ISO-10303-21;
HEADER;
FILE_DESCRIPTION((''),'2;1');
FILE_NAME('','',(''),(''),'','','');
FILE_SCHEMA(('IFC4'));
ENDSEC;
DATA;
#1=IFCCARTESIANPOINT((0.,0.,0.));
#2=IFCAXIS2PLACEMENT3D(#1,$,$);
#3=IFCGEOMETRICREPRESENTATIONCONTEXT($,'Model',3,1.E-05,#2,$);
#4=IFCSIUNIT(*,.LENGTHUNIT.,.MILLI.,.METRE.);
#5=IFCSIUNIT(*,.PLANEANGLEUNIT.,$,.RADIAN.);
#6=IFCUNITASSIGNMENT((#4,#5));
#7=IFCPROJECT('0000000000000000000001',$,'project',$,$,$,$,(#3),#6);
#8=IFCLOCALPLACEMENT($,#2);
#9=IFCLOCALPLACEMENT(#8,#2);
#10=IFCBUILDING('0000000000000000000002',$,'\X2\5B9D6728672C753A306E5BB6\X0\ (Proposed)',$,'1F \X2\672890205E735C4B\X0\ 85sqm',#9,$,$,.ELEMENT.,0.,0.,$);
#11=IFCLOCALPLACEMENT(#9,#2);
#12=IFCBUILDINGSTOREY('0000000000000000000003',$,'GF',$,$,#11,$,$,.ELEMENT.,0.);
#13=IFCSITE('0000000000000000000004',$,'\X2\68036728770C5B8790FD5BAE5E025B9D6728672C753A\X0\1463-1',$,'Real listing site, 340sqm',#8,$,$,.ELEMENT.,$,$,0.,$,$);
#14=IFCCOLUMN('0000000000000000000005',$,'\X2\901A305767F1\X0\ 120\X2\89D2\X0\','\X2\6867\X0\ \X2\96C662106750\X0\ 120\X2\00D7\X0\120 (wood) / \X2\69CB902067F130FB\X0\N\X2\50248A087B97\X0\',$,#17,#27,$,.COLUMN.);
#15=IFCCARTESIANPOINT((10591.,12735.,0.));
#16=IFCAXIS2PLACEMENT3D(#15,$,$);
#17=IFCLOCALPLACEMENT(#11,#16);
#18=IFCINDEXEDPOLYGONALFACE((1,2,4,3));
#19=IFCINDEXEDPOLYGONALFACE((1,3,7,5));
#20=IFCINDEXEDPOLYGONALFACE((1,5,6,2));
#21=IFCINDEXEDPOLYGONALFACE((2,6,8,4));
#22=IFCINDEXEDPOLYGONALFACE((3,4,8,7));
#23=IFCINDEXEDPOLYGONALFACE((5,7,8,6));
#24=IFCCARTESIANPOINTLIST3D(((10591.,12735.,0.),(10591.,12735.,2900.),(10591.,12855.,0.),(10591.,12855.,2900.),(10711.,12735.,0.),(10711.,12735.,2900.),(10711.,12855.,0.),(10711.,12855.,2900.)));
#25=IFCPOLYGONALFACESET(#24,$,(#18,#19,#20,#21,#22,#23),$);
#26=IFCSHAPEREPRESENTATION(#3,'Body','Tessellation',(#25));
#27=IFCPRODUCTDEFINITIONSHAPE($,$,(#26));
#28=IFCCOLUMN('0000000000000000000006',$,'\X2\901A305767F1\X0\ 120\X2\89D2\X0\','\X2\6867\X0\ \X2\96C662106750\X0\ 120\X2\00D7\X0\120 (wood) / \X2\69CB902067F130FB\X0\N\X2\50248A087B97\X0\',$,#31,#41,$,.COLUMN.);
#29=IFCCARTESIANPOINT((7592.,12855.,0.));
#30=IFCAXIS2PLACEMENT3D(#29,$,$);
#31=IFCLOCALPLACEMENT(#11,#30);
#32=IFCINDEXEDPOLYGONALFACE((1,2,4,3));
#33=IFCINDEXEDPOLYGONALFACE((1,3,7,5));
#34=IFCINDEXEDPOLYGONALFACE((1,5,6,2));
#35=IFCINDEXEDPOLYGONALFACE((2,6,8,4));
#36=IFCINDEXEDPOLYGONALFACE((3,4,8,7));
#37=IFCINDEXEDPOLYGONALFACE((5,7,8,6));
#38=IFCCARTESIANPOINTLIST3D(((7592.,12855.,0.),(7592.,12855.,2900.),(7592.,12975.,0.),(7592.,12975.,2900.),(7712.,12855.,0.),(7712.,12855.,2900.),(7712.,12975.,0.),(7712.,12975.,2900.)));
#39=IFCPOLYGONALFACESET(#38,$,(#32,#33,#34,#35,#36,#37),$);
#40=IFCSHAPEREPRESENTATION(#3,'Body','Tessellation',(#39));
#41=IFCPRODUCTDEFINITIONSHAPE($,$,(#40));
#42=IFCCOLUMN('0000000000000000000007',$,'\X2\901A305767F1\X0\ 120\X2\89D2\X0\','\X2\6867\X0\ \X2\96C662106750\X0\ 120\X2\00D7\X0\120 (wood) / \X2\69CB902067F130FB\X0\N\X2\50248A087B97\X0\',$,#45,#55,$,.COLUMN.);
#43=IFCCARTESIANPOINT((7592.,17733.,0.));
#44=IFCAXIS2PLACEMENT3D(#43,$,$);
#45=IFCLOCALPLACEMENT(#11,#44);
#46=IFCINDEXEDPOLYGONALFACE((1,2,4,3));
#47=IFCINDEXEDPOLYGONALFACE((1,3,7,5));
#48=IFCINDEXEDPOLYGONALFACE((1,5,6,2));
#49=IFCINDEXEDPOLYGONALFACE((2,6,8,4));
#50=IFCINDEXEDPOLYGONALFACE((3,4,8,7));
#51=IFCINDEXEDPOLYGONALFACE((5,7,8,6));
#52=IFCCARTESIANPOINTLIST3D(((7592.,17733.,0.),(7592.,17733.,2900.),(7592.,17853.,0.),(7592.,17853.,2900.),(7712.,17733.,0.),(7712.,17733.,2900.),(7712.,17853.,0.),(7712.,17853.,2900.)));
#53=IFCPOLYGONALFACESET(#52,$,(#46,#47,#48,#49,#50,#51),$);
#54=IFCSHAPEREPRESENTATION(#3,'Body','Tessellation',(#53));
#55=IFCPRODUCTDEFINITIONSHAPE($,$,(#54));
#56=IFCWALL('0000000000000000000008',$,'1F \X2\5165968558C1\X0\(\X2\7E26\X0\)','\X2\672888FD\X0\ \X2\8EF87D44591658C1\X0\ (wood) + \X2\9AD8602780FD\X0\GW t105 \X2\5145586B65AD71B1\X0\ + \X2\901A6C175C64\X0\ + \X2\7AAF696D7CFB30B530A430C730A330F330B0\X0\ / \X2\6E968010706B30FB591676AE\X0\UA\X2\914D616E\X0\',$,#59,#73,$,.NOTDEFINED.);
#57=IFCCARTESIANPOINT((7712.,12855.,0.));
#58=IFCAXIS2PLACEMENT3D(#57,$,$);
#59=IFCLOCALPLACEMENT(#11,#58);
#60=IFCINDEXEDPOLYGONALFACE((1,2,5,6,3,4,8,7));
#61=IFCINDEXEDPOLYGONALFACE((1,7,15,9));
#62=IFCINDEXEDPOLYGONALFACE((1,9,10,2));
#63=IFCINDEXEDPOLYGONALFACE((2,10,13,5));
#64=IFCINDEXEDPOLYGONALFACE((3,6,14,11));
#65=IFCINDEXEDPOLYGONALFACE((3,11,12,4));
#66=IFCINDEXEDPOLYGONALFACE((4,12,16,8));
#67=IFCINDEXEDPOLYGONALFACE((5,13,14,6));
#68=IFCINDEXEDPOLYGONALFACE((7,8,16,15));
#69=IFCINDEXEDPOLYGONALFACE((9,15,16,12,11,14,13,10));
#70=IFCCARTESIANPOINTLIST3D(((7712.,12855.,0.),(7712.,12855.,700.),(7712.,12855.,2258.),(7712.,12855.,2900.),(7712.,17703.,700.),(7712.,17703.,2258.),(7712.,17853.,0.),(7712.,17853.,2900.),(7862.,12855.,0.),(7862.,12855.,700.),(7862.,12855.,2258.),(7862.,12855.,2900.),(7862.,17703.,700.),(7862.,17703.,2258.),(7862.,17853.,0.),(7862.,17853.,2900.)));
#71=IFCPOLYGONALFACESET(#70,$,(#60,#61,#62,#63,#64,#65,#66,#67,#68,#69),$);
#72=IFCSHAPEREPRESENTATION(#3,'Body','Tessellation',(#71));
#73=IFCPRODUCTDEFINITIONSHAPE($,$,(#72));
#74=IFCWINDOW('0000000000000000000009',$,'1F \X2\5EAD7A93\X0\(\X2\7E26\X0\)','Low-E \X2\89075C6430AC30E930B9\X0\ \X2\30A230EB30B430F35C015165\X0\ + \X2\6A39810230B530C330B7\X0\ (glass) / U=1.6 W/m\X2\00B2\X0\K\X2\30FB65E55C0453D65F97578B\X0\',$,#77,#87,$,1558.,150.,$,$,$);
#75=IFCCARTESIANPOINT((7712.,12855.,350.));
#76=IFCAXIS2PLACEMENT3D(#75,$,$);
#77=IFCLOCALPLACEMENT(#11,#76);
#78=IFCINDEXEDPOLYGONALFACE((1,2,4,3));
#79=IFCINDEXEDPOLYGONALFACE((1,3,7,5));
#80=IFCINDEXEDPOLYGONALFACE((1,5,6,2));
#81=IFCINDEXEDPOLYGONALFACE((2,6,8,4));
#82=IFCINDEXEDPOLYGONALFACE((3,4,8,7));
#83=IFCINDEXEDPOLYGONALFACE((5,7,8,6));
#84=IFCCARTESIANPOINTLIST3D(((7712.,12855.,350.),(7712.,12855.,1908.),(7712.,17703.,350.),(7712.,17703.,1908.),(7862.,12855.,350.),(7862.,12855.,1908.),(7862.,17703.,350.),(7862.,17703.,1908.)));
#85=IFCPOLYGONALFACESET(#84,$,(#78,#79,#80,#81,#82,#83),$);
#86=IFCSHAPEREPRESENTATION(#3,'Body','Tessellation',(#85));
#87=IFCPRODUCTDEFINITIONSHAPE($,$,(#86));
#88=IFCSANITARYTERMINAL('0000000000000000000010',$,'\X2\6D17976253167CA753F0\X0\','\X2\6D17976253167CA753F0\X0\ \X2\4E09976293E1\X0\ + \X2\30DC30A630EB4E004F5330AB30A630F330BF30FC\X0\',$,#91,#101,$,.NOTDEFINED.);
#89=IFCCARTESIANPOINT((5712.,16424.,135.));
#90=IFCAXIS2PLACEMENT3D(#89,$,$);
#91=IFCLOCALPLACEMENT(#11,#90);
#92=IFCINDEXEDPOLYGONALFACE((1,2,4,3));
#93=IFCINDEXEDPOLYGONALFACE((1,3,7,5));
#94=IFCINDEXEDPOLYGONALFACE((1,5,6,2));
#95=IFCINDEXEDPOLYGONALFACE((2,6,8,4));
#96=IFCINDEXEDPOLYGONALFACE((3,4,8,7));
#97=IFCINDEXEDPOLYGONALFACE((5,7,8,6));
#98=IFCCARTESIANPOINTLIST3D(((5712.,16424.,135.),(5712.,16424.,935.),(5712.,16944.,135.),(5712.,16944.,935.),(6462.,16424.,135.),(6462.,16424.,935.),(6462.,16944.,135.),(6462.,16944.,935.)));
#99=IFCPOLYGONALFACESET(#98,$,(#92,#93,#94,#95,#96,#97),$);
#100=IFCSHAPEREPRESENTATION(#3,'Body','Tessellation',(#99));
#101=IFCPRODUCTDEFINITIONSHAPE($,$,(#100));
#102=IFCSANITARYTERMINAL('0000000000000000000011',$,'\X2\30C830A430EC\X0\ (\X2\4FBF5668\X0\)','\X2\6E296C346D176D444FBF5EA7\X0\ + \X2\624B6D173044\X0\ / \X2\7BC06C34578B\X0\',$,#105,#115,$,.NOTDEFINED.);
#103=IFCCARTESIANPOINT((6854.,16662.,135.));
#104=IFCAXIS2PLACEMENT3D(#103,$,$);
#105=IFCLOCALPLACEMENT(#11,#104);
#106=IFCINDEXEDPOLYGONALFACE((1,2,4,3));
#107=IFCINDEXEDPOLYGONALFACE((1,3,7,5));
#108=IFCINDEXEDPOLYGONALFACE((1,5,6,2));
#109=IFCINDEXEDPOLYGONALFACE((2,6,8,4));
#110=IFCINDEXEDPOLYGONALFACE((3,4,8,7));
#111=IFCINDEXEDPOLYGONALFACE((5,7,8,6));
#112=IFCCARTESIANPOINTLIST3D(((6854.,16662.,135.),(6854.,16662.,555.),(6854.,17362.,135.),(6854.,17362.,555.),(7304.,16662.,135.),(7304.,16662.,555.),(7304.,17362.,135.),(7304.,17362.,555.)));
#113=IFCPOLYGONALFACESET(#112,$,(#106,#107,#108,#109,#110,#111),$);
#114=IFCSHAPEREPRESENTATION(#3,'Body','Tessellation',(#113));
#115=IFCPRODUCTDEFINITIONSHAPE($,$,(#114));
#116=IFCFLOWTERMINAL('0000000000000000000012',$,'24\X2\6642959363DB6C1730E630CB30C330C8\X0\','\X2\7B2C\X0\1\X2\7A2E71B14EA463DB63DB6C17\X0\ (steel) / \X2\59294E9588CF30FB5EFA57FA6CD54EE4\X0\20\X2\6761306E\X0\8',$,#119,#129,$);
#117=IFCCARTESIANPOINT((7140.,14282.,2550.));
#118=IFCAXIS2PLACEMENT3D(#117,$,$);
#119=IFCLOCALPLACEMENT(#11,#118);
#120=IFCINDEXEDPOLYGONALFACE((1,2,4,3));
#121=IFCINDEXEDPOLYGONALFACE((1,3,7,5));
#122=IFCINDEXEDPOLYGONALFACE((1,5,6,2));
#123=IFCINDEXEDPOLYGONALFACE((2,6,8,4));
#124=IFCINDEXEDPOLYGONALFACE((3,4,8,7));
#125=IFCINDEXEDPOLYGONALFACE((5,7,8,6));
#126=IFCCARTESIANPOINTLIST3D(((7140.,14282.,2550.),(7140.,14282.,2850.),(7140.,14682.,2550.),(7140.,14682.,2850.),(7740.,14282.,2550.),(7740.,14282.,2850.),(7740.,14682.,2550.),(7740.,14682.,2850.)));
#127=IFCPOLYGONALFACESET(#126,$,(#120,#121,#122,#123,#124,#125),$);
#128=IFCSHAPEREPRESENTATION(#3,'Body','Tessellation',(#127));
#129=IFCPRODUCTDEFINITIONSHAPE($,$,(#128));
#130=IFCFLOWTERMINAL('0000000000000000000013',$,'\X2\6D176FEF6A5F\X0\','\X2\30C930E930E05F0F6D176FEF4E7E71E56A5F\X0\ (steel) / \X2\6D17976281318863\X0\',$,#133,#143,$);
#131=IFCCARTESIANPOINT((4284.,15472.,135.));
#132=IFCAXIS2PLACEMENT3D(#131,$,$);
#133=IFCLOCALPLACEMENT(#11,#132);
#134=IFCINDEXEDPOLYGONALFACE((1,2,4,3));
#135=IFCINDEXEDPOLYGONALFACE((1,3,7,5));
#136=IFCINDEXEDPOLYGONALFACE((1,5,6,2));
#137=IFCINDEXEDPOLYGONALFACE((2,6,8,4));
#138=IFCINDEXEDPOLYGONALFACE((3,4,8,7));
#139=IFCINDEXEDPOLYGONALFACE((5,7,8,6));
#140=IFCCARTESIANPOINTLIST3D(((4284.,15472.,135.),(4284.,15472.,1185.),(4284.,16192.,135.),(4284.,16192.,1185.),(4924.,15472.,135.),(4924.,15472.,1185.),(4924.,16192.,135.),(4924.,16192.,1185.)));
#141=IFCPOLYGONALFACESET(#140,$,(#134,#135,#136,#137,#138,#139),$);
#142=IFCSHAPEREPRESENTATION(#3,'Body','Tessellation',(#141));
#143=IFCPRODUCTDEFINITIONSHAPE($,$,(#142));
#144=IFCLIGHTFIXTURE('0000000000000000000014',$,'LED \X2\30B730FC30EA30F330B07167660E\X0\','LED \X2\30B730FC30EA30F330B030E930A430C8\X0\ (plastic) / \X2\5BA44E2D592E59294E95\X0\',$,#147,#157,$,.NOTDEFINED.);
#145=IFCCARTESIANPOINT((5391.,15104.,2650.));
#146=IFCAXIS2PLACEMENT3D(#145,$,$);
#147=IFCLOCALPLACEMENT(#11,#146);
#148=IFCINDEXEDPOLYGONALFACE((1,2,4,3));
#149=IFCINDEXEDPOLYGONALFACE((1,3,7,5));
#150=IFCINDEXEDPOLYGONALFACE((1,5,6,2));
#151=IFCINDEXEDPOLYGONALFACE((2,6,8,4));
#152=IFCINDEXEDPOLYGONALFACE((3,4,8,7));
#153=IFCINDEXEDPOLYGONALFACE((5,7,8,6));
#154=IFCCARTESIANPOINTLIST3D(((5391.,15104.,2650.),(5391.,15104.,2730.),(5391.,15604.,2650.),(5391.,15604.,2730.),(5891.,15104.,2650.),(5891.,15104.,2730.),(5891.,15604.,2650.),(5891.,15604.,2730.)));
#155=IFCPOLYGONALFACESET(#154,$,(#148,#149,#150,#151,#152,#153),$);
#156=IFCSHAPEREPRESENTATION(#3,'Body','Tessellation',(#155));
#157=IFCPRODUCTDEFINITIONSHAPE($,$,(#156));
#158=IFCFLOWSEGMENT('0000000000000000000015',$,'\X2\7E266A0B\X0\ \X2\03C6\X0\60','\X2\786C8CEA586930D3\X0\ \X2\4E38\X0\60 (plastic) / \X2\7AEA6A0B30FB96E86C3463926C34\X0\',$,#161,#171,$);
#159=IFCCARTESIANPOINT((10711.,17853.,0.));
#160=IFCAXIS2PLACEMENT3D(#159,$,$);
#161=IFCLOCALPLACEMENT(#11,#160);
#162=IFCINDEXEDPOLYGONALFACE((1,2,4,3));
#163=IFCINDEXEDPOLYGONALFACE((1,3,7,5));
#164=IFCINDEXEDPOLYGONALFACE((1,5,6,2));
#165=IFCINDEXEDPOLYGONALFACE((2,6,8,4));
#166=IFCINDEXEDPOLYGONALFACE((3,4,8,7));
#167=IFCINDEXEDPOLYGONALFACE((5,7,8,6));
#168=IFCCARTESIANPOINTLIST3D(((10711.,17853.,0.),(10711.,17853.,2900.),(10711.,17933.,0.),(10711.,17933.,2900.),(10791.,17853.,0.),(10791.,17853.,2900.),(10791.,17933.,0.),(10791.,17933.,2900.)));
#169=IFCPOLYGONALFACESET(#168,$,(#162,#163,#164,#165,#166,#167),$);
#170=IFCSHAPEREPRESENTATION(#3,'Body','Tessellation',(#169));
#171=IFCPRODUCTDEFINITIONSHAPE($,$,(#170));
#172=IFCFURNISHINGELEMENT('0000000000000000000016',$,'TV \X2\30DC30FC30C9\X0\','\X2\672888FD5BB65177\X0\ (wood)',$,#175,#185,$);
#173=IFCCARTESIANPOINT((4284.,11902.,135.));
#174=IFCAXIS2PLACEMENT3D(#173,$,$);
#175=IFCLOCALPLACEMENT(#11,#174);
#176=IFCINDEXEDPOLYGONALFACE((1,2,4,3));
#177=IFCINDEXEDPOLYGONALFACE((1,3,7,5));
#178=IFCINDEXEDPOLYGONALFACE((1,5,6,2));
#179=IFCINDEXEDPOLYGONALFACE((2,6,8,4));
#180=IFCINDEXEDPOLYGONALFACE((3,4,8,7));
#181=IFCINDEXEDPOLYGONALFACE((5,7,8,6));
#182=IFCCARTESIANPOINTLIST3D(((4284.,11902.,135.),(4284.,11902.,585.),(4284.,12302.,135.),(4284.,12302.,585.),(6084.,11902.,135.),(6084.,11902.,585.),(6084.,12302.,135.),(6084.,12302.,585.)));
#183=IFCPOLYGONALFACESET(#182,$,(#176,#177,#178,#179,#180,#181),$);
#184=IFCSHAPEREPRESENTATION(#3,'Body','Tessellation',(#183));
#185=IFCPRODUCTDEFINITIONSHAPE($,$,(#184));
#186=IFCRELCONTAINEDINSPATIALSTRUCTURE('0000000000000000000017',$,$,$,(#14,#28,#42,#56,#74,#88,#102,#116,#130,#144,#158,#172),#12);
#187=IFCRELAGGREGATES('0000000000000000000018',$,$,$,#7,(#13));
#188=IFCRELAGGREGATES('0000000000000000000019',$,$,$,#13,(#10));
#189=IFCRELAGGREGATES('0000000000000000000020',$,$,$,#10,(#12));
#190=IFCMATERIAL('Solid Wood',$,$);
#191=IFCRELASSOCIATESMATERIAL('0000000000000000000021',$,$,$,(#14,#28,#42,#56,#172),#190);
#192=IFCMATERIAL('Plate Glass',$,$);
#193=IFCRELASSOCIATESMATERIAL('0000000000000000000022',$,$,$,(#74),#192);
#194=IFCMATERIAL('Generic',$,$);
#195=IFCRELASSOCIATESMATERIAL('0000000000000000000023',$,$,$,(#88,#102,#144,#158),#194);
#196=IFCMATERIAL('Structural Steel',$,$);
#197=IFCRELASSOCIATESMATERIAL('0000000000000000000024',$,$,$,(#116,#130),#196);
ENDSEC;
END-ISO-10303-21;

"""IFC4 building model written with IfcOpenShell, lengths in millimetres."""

from ifc_helpers import new_model, si_unit, frame, frame_2d, origin, place, context, project, spatial, rectangle, extrude, material, element, fill, save


model = new_model("IFC4")

# Units and contexts
model_context = context("Model", 3, precision=1e-05, world=origin())
ifc_project = project(units=[si_unit("LENGTHUNIT", "METRE", prefix="MILLI"), si_unit("PLANEANGLEUNIT", "RADIAN")], contexts=[model_context])

# Site, building, storey
site_placement = place(None, origin())
site = spatial("IfcSite", under=ifc_project, at=site_placement, Name="栃木県宇都宮市宝木本町1463-1", ObjectType="Real listing site, 340sqm", CompositionType="ELEMENT", RefElevation=0.0)
building_placement = place(site_placement, origin())
building = spatial("IfcBuilding", under=site, at=building_placement, Name="宝木本町の家 (Proposed)", ObjectType="1F 木造平屋 85sqm", CompositionType="ELEMENT", ElevationOfRefHeight=0.0, ElevationOfTerrain=0.0)
storey_placement = place(building_placement, origin())
storey = spatial("IfcBuildingStorey", under=building, at=storey_placement, Name="GF", CompositionType="ELEMENT", Elevation=0.0)

# Columns
ifc_material_1 = material(Name="Solid Wood")
column_1_placement = place(storey_placement, frame((10591.0, 12735.0, 0.0)))
element("IfcColumn", 1, at=column_1_placement, inside=storey, material=ifc_material_1, Name="通し柱 120角", Description="桧 集成材 120×120 (wood) / 構造柱・N値計算", PredefinedType="COLUMN", context=model_context, shape_type="SweptSolid", body=[
    extrude(rectangle(XDim=120.0, YDim=120.0, at=frame_2d((60.0, 60.0))), frame((10591.0, 12735.0, 0.0)), (0.0, 0.0, 1.0), 2900.0),
])
column_2_placement = place(storey_placement, frame((7592.0, 12855.0, 0.0)))
element("IfcColumn", 2, at=column_2_placement, inside=storey, material=ifc_material_1, Name="通し柱 120角", Description="桧 集成材 120×120 (wood) / 構造柱・N値計算", PredefinedType="COLUMN", context=model_context, shape_type="SweptSolid", body=[
    extrude(rectangle(XDim=120.0, YDim=120.0, at=frame_2d((60.0, 60.0))), frame((7592.0, 12855.0, 0.0)), (0.0, 0.0, 1.0), 2900.0),
])
column_3_placement = place(storey_placement, frame((7592.0, 17733.0, 0.0)))
element("IfcColumn", 3, at=column_3_placement, inside=storey, material=ifc_material_1, Name="通し柱 120角", Description="桧 集成材 120×120 (wood) / 構造柱・N値計算", PredefinedType="COLUMN", context=model_context, shape_type="SweptSolid", body=[
    extrude(rectangle(XDim=120.0, YDim=120.0, at=frame_2d((60.0, 60.0))), frame((7592.0, 17733.0, 0.0)), (0.0, 0.0, 1.0), 2900.0),
])

# Wall, opening, window
wall_1_placement = place(storey_placement, frame((7712.0, 12855.0, 0.0)))
wall_1 = element("IfcWall", 4, at=wall_1_placement, inside=storey, material=ifc_material_1, Name="1F 入隅壁(縦)", Description="木製 軸組外壁 (wood) + 高性能GW t105 充填断熱 + 通気層 + 窯業系サイディング / 準耐火・外皮UA配慮", PredefinedType="NOTDEFINED", context=model_context, shape_type="SweptSolid", body=[
    extrude(rectangle(XDim=150.0, YDim=4998.0, at=frame_2d((75.0, 2499.0))), frame((7712.0, 12855.0, 0.0)), (0.0, 0.0, 1.0), 2900.0),
])
opening_placement = place(storey_placement, frame((7712.0, 12855.0, 350.0)))
opening = element("IfcOpeningElement", 5, at=opening_placement, cuts=wall_1, PredefinedType="NOTDEFINED", context=model_context, shape_type="SweptSolid", body=[
    extrude(rectangle(XDim=150.0, YDim=4848.0, at=frame_2d((75.0, 2424.0))), frame((7712.0, 12855.0, 350.0)), (0.0, 0.0, 1.0), 1558.0),
])
ifc_material_2 = material(Name="Plate Glass")
window_placement = place(storey_placement, frame((7712.0, 12855.0, 350.0)))
window = element("IfcWindow", 6, at=window_placement, inside=storey, material=ifc_material_2, Name="1F 庭窓(縦)", Description="Low-E 複層ガラス アルゴン封入 + 樹脂サッシ (glass) / U=1.6 W/m²K・日射取得型", OverallHeight=1558.0, OverallWidth=150.0, context=model_context, shape_type="SweptSolid", body=[
    extrude(rectangle(XDim=150.0, YDim=4848.0, at=frame_2d((75.0, 2424.0))), frame((7712.0, 12855.0, 350.0)), (0.0, 0.0, 1.0), 1558.0),
])
fill(opening, window)

# Sanitary terminals
ifc_material_3 = material(Name="Generic")
sanitary_terminal_1_placement = place(storey_placement, frame((5712.0, 16424.0, 135.0)))
element("IfcSanitaryTerminal", 7, at=sanitary_terminal_1_placement, inside=storey, material=ifc_material_3, Name="洗面化粧台", Description="洗面化粧台 三面鏡 + ボウル一体カウンター", PredefinedType="NOTDEFINED", context=model_context, shape_type="SweptSolid", body=[
    extrude(rectangle(XDim=750.0, YDim=520.0, at=frame_2d((375.0, 260.0))), frame((5712.0, 16424.0, 135.0)), (0.0, 0.0, 1.0), 800.0),
])
sanitary_terminal_2_placement = place(storey_placement, frame((6854.0, 16662.0, 135.0)))
element("IfcSanitaryTerminal", 8, at=sanitary_terminal_2_placement, inside=storey, material=ifc_material_3, Name="トイレ (便器)", Description="温水洗浄便座 + 手洗い / 節水型", PredefinedType="NOTDEFINED", context=model_context, shape_type="SweptSolid", body=[
    extrude(rectangle(XDim=450.0, YDim=700.0, at=frame_2d((225.0, 350.0))), frame((6854.0, 16662.0, 135.0)), (0.0, 0.0, 1.0), 420.0),
])

# Flow terminals
ifc_material_4 = material(Name="Structural Steel")
flow_terminal_1_placement = place(storey_placement, frame((7140.0, 14282.0, 2550.0)))
element("IfcFlowTerminal", 9, at=flow_terminal_1_placement, inside=storey, material=ifc_material_4, Name="24時間換気ユニット", Description="第1種熱交換換気 (steel) / 天井裏・建基法令20条の8", context=model_context, shape_type="SweptSolid", body=[
    extrude(rectangle(XDim=600.0, YDim=400.0, at=frame_2d((300.0, 200.0))), frame((7140.0, 14282.0, 2550.0)), (0.0, 0.0, 1.0), 300.0),
])
flow_terminal_2_placement = place(storey_placement, frame((4284.0, 15472.0, 135.0)))
element("IfcFlowTerminal", 10, at=flow_terminal_2_placement, inside=storey, material=ifc_material_4, Name="洗濯機", Description="ドラム式洗濯乾燥機 (steel) / 洗面脱衣", context=model_context, shape_type="SweptSolid", body=[
    extrude(rectangle(XDim=640.0, YDim=720.0, at=frame_2d((320.0, 360.0))), frame((4284.0, 15472.0, 135.0)), (0.0, 0.0, 1.0), 1050.0),
])

# Light fixture
light_fixture_placement = place(storey_placement, frame((5391.0, 15104.0, 2650.0)))
element("IfcLightFixture", 11, at=light_fixture_placement, inside=storey, material=ifc_material_3, Name="LED シーリング照明", Description="LED シーリングライト (plastic) / 室中央天井", PredefinedType="NOTDEFINED", context=model_context, shape_type="SweptSolid", body=[
    extrude(rectangle(XDim=500.0, YDim=500.0, at=frame_2d((250.0, 250.0))), frame((5391.0, 15104.0, 2650.0)), (0.0, 0.0, 1.0), 80.0),
])

# Flow segment
flow_segment_placement = place(storey_placement, frame((10711.0, 17853.0, 0.0)))
element("IfcFlowSegment", 12, at=flow_segment_placement, inside=storey, material=ifc_material_3, Name="縦樋 φ60", Description="硬質塩ビ 丸60 (plastic) / 竪樋・雨水排水", context=model_context, shape_type="SweptSolid", body=[
    extrude(rectangle(XDim=80.0, YDim=80.0, at=frame_2d((40.0, 40.0))), frame((10711.0, 17853.0, 0.0)), (0.0, 0.0, 1.0), 2900.0),
])

# Furnishing element
furnishing_placement = place(storey_placement, frame((4284.0, 11902.0, 135.0)))
element("IfcFurnishingElement", 13, at=furnishing_placement, inside=storey, material=ifc_material_1, Name="TV ボード", Description="木製家具 (wood)", context=model_context, shape_type="SweptSolid", body=[
    extrude(rectangle(XDim=1800.0, YDim=400.0, at=frame_2d((900.0, 200.0))), frame((4284.0, 11902.0, 135.0)), (0.0, 0.0, 1.0), 450.0),
])

save(model, "model.ifc")
